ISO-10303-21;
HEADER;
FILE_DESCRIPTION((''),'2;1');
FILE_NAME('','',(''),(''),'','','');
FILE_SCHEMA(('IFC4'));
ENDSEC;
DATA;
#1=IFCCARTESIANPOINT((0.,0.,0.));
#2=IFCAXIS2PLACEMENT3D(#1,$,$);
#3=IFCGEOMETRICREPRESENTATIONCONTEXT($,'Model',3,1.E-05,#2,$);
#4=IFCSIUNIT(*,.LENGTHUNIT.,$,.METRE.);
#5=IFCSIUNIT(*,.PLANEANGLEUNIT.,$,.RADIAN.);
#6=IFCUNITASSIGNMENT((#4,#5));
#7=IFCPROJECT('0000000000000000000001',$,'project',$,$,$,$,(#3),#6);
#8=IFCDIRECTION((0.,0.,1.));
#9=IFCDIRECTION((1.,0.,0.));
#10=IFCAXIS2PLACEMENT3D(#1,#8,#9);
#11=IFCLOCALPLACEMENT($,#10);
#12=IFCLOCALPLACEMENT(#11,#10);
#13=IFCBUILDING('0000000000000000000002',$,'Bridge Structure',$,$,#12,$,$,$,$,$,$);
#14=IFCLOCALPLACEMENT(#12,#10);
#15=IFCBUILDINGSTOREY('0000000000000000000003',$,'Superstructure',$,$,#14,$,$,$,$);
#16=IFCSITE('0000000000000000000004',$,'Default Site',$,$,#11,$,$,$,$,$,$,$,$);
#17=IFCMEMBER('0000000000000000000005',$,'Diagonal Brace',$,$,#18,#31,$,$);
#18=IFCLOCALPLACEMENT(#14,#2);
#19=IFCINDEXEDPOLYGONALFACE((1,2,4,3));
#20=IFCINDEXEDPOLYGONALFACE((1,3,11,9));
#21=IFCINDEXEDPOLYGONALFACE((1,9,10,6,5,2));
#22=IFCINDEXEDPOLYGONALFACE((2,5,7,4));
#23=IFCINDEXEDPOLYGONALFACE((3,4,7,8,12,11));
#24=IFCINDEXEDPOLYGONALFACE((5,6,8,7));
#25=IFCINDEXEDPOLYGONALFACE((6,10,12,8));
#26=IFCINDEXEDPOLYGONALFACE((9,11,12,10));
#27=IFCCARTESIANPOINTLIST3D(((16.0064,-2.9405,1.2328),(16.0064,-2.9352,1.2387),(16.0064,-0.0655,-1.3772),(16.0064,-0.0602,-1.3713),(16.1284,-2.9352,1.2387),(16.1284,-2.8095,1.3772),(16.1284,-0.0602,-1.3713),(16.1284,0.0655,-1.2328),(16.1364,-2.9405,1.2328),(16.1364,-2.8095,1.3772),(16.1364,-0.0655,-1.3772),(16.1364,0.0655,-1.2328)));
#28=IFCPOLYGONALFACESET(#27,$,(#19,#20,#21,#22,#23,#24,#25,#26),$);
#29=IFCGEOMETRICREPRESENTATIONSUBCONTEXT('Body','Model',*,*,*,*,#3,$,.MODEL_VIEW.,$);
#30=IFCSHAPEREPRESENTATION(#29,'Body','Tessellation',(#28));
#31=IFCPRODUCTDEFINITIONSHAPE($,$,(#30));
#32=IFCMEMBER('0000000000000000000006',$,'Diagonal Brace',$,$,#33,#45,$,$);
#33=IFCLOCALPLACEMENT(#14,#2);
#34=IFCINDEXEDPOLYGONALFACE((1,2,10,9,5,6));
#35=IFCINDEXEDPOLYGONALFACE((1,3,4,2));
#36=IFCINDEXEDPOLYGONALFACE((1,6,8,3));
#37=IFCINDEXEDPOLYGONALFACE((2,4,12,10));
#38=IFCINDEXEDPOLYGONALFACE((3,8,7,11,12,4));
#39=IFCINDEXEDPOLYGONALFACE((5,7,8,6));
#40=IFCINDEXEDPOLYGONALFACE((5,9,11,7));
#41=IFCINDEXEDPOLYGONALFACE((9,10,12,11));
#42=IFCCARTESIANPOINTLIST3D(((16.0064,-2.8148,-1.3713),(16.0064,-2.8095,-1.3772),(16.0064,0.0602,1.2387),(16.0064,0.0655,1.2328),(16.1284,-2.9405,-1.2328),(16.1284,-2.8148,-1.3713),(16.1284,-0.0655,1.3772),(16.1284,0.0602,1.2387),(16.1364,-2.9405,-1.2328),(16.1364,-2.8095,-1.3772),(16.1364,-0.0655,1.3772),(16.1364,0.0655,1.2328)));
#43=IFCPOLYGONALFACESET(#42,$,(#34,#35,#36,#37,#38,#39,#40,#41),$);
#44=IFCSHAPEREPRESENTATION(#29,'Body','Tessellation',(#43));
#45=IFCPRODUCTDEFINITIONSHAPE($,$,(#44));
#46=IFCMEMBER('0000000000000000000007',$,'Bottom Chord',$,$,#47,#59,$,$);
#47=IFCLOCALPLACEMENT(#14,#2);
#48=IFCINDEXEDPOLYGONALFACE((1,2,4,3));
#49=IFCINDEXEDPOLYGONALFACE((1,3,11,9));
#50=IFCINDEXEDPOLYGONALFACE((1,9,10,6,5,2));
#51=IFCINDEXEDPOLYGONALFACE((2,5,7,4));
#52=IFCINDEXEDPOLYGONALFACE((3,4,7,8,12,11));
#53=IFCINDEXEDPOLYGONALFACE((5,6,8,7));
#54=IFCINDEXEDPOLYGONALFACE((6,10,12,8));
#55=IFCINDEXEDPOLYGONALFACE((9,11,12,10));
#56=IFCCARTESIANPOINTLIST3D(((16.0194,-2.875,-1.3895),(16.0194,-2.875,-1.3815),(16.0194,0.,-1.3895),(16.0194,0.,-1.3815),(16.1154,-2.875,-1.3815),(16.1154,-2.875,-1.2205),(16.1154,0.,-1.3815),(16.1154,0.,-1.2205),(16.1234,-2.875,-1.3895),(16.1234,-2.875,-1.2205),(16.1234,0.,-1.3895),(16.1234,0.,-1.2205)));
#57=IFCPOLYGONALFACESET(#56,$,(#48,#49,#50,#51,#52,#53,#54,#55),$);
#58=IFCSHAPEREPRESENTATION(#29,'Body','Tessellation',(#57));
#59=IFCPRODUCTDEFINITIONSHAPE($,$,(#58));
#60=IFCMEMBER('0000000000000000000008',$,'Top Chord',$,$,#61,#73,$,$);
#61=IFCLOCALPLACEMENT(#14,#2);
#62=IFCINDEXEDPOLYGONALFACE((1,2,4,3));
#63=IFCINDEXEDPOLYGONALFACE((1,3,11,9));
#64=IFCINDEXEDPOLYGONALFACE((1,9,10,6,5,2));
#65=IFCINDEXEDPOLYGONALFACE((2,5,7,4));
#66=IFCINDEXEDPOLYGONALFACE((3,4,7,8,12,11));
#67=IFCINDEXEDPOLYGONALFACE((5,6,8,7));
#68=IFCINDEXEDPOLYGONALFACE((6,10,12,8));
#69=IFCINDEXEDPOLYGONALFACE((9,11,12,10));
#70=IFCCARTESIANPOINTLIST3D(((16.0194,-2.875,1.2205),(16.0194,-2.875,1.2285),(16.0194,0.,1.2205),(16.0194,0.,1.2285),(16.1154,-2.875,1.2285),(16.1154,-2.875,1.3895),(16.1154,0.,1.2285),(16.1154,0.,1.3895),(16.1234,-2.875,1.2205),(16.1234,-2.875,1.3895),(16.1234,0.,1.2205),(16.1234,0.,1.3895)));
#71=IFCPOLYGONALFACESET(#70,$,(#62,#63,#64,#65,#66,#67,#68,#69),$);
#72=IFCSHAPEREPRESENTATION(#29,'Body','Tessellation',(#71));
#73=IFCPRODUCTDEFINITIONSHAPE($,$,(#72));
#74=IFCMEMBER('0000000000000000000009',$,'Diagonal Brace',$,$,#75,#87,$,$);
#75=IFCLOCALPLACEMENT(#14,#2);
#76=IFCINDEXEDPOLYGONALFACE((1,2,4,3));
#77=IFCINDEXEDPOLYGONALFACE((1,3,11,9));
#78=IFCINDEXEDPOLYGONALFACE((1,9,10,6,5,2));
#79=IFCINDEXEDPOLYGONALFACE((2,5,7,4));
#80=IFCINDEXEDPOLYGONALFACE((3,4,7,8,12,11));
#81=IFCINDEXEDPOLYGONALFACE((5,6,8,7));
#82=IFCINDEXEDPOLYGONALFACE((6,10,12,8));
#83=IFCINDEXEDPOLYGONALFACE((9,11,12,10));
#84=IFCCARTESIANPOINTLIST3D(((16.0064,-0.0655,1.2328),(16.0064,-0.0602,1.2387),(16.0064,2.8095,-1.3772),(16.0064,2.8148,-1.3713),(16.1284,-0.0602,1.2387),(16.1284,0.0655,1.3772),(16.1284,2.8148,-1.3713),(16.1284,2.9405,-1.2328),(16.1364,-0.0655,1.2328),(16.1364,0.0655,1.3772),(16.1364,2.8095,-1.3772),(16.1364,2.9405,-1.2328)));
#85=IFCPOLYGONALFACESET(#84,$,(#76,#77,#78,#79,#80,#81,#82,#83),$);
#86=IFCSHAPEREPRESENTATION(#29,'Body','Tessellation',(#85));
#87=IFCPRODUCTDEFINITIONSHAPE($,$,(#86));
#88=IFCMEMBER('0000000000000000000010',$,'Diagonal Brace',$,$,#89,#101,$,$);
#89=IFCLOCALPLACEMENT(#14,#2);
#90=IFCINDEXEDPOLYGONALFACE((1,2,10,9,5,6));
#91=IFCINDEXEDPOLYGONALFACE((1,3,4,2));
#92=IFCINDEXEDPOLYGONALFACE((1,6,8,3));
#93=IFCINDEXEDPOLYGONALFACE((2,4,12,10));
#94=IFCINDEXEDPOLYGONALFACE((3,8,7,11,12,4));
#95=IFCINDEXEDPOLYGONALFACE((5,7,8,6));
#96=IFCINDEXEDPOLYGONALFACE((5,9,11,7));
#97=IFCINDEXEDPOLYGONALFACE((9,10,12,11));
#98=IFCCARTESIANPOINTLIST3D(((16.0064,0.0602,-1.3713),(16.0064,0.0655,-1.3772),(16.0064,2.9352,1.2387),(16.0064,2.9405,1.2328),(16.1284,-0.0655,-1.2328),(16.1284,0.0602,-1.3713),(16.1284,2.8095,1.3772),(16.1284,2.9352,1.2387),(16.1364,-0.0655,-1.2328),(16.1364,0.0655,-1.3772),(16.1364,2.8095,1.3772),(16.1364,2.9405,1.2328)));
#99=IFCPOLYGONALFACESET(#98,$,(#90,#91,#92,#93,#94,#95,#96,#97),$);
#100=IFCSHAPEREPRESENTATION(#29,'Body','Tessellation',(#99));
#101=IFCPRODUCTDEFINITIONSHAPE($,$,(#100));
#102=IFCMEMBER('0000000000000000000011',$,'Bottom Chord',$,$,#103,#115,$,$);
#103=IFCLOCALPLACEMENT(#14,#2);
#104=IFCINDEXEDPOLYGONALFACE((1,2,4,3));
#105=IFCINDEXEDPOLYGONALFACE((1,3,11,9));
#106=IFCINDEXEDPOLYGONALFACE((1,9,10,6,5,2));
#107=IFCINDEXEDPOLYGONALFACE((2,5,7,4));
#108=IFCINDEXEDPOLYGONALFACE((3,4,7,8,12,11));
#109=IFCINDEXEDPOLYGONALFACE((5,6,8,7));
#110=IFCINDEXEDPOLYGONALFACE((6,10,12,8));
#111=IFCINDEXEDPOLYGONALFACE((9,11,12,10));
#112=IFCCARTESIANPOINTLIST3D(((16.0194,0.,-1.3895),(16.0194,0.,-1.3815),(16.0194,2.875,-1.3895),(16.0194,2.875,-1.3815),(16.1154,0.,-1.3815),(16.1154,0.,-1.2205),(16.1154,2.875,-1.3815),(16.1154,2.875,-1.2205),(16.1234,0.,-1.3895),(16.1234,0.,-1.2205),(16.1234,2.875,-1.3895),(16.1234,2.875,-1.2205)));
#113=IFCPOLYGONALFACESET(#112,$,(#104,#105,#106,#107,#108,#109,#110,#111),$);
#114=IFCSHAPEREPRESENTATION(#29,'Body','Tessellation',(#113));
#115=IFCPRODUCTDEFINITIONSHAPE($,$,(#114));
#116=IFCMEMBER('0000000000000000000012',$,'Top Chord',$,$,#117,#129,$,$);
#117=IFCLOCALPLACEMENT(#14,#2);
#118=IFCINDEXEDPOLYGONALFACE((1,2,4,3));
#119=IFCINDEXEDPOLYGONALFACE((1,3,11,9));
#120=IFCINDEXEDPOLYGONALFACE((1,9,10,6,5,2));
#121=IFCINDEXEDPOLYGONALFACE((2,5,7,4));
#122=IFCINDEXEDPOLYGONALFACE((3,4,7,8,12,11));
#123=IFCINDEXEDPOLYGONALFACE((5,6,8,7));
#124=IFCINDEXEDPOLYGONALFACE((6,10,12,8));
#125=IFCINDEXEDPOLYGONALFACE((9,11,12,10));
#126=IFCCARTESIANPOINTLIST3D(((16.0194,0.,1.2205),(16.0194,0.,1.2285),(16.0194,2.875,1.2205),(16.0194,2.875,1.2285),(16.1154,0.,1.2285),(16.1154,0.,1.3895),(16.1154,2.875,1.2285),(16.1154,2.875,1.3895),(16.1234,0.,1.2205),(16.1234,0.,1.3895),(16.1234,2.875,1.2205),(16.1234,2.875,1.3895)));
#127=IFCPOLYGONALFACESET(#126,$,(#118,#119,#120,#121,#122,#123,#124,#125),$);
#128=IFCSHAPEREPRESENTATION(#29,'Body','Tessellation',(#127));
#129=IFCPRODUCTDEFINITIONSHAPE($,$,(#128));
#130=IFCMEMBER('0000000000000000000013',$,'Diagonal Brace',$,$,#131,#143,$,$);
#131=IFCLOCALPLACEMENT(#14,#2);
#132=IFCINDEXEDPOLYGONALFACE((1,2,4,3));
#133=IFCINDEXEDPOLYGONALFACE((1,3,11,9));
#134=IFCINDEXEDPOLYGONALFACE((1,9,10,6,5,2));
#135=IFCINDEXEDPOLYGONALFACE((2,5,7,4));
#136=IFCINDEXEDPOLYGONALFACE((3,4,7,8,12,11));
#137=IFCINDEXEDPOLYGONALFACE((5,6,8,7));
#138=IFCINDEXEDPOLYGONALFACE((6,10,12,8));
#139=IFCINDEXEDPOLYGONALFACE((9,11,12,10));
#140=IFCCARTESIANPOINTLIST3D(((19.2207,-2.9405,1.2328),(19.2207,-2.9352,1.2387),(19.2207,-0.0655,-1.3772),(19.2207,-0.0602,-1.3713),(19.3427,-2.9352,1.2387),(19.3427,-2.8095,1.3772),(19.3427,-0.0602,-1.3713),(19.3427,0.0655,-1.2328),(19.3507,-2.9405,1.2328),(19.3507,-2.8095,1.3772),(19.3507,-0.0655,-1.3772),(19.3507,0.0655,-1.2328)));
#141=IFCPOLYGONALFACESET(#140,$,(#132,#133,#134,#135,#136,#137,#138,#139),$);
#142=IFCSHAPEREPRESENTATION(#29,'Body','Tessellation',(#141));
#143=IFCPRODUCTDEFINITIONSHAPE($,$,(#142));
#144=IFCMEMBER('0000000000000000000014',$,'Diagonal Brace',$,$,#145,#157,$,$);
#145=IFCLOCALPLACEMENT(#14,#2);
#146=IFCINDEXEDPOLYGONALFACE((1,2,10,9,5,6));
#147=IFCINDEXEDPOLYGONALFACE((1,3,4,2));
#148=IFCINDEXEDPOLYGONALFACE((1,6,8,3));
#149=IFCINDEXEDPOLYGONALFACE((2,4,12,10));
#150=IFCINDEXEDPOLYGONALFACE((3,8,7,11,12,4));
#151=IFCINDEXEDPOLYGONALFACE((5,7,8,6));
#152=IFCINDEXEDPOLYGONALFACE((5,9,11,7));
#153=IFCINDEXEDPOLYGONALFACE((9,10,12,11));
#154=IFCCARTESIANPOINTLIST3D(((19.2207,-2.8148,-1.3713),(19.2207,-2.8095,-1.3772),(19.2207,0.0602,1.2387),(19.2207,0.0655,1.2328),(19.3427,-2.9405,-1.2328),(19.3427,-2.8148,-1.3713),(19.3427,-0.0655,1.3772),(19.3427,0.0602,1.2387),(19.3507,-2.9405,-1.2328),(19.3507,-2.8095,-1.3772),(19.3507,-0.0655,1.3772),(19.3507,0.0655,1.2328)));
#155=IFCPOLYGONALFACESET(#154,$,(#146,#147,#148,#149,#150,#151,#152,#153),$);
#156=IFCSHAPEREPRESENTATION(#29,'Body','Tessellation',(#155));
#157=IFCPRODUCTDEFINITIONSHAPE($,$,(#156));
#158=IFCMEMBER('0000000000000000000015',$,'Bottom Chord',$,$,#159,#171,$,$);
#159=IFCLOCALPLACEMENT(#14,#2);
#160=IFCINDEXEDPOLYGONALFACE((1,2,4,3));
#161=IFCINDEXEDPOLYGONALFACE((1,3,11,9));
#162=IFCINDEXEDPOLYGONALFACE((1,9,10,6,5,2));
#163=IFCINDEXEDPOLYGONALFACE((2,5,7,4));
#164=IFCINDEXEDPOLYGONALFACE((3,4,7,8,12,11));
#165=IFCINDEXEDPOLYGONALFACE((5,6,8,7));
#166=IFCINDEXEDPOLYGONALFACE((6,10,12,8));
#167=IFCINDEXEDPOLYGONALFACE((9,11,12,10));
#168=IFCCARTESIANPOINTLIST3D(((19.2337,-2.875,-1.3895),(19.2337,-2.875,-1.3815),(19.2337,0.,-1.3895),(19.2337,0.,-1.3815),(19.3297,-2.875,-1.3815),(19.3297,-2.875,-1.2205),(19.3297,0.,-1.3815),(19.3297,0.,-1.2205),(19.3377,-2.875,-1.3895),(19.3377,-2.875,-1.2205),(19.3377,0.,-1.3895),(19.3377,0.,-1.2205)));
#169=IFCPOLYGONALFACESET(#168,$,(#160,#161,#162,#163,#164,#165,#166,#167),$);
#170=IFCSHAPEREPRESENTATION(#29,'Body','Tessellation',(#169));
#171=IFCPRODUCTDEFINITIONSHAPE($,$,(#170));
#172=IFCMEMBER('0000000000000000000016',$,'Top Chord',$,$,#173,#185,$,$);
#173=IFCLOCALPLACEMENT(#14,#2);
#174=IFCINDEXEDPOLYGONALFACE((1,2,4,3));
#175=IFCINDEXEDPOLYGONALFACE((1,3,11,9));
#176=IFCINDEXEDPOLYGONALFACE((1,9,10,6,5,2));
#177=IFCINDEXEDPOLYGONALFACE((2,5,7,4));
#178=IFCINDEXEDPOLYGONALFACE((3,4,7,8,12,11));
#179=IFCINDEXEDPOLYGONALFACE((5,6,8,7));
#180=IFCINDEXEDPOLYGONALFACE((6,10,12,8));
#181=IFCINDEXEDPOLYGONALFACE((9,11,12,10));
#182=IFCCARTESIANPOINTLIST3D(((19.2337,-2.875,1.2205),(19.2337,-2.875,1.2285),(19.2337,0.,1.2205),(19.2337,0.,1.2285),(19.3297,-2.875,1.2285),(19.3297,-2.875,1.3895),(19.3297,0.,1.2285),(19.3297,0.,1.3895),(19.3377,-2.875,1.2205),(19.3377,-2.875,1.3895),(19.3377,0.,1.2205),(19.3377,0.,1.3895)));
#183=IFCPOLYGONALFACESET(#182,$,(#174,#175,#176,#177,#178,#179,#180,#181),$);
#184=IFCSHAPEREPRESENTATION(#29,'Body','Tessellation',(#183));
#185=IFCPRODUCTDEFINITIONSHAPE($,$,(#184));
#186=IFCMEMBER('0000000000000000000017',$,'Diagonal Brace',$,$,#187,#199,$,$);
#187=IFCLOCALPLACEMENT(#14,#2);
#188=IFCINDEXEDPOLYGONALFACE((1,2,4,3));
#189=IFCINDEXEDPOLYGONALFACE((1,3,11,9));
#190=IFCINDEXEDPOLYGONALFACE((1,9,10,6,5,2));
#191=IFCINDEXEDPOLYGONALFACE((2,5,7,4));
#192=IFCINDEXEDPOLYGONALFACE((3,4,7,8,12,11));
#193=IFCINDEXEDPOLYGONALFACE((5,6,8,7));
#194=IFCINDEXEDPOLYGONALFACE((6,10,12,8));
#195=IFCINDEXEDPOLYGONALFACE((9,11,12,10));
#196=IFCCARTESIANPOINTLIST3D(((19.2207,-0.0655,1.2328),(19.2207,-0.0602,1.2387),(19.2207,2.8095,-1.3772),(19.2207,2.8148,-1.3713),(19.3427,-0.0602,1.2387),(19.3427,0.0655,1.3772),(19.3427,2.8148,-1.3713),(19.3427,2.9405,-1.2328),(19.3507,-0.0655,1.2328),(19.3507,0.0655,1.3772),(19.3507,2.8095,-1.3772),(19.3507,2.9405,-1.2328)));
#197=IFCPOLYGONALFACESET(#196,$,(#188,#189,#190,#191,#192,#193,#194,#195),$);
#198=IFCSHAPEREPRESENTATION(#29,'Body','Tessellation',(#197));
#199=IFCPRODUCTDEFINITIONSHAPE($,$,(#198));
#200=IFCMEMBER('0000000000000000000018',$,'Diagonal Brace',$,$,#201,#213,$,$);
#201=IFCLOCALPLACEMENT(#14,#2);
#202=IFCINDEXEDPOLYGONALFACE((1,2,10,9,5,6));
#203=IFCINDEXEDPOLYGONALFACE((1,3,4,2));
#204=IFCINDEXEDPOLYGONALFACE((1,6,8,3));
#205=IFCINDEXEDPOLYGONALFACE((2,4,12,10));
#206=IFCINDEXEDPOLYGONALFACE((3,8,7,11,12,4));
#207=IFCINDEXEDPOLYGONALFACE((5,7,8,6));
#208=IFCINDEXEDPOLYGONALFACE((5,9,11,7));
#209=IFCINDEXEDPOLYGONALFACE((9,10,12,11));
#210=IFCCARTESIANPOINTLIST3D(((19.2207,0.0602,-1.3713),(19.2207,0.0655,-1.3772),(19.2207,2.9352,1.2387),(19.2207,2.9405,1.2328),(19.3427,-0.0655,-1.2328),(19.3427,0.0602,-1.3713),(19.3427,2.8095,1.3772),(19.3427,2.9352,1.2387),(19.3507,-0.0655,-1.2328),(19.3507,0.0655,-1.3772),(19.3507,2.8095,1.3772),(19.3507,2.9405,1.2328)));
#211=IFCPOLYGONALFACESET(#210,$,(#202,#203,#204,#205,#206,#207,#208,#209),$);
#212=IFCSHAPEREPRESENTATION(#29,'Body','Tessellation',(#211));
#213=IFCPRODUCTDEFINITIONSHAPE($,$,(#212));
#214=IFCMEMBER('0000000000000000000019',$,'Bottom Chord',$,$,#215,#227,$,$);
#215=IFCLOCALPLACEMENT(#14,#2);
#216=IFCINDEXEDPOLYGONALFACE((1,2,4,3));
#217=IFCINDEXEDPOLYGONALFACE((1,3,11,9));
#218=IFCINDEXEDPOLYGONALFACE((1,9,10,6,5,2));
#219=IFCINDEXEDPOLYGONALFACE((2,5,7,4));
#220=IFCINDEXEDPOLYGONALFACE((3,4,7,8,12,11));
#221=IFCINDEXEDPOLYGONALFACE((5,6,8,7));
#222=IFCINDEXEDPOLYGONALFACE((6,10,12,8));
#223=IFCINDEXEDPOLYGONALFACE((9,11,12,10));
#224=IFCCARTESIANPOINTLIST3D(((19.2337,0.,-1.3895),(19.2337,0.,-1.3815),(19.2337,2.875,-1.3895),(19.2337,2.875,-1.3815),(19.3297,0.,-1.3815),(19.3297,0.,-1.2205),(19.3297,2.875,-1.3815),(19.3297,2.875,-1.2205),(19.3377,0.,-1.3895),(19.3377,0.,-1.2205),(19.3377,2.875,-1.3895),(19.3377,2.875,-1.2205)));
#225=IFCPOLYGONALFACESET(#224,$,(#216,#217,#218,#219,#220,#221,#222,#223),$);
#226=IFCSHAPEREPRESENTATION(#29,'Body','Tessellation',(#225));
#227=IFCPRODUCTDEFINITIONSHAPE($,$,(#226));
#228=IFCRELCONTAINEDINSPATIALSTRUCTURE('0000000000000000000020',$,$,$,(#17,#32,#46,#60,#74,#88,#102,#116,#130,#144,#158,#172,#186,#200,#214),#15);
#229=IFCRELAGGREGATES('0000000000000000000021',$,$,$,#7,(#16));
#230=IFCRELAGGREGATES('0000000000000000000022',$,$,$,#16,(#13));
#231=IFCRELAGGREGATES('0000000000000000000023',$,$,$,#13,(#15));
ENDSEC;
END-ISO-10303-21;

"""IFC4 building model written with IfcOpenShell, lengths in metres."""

from ifc_helpers import new_model, si_unit, frame, origin, origin_with_axes, origin_2d_with_axis, place, context, subcontext, project, spatial, l_section, extrude, element, save


model = new_model("IFC4")

# Units and contexts
model_context = context("Model", 3, precision=1e-05, world=origin())
body_context = subcontext(model_context, "Body", "Model", "MODEL_VIEW")
ifc_project = project(units=[si_unit("LENGTHUNIT", "METRE"), si_unit("PLANEANGLEUNIT", "RADIAN")], contexts=[model_context])

# Site, building, storey
site_placement = place(None, origin_with_axes())
site = spatial("IfcSite", under=ifc_project, at=site_placement, Name="Default Site")
building_placement = place(site_placement, origin_with_axes())
building = spatial("IfcBuilding", under=site, at=building_placement, Name="Bridge Structure")
storey_placement = place(building_placement, origin_with_axes())
storey = spatial("IfcBuildingStorey", under=building, at=storey_placement, Name="Superstructure")

# Members
for number, where, z_axis, x_axis, name in (
    (1, (16.0714, -2.875, 1.305), (0.0, 0.740406, -0.67216), (-1.0, 0.0, 0.0), "Diagonal Brace"),
    (2, (16.0714, -2.875, -1.305), (0.0, 0.740406, 0.67216), (-1.0, 0.0, 0.0), "Diagonal Brace"),
):
    element("IfcMember", number, at=place(storey_placement, frame(where, z_axis=z_axis, x_axis=x_axis)), inside=storey, Name=name, context=body_context, shape_type="SweptSolid", body=[
        extrude(l_section(Depth=0.195, Width=0.13, Thickness=0.008, at=origin_2d_with_axis()), origin_with_axes(), (0.0, 0.0, 1.0), 3.883),
    ])
for number, where, z_axis, x_axis, name in (
    (3, (16.0714, -2.875, -1.305), (0.0, 1.0, 0.0), (-1.0, 0.0, 0.0), "Bottom Chord"),
    (4, (16.0714, -2.875, 1.305), (0.0, 1.0, 0.0), (-1.0, 0.0, 0.0), "Top Chord"),
):
    element("IfcMember", number, at=place(storey_placement, frame(where, z_axis=z_axis, x_axis=x_axis)), inside=storey, Name=name, context=body_context, shape_type="SweptSolid", body=[
        extrude(l_section(Depth=0.169, Width=0.104, Thickness=0.008, at=origin_2d_with_axis()), origin_with_axes(), (0.0, 0.0, 1.0), 2.875),
    ])
for number, where, z_axis, x_axis, name in (
    (5, (16.0714, 0.0, 1.305), (0.0, 0.740406, -0.67216), (-1.0, 0.0, 0.0), "Diagonal Brace"),
    (6, (16.0714, 0.0, -1.305), (0.0, 0.740406, 0.67216), (-1.0, 0.0, 0.0), "Diagonal Brace"),
):
    element("IfcMember", number, at=place(storey_placement, frame(where, z_axis=z_axis, x_axis=x_axis)), inside=storey, Name=name, context=body_context, shape_type="SweptSolid", body=[
        extrude(l_section(Depth=0.195, Width=0.13, Thickness=0.008, at=origin_2d_with_axis()), origin_with_axes(), (0.0, 0.0, 1.0), 3.883),
    ])
for number, where, z_axis, x_axis, name in (
    (7, (16.0714, 0.0, -1.305), (0.0, 1.0, 0.0), (-1.0, 0.0, 0.0), "Bottom Chord"),
    (8, (16.0714, 0.0, 1.305), (0.0, 1.0, 0.0), (-1.0, 0.0, 0.0), "Top Chord"),
):
    element("IfcMember", number, at=place(storey_placement, frame(where, z_axis=z_axis, x_axis=x_axis)), inside=storey, Name=name, context=body_context, shape_type="SweptSolid", body=[
        extrude(l_section(Depth=0.169, Width=0.104, Thickness=0.008, at=origin_2d_with_axis()), origin_with_axes(), (0.0, 0.0, 1.0), 2.875),
    ])
for number, where, z_axis, x_axis, name in (
    (9, (19.2857, -2.875, 1.305), (0.0, 0.740406, -0.67216), (-1.0, 0.0, 0.0), "Diagonal Brace"),
    (10, (19.2857, -2.875, -1.305), (0.0, 0.740406, 0.67216), (-1.0, 0.0, 0.0), "Diagonal Brace"),
):
    element("IfcMember", number, at=place(storey_placement, frame(where, z_axis=z_axis, x_axis=x_axis)), inside=storey, Name=name, context=body_context, shape_type="SweptSolid", body=[
        extrude(l_section(Depth=0.195, Width=0.13, Thickness=0.008, at=origin_2d_with_axis()), origin_with_axes(), (0.0, 0.0, 1.0), 3.883),
    ])
for number, where, z_axis, x_axis, name in (
    (11, (19.2857, -2.875, -1.305), (0.0, 1.0, 0.0), (-1.0, 0.0, 0.0), "Bottom Chord"),
    (12, (19.2857, -2.875, 1.305), (0.0, 1.0, 0.0), (-1.0, 0.0, 0.0), "Top Chord"),
):
    element("IfcMember", number, at=place(storey_placement, frame(where, z_axis=z_axis, x_axis=x_axis)), inside=storey, Name=name, context=body_context, shape_type="SweptSolid", body=[
        extrude(l_section(Depth=0.169, Width=0.104, Thickness=0.008, at=origin_2d_with_axis()), origin_with_axes(), (0.0, 0.0, 1.0), 2.875),
    ])
for number, where, z_axis, x_axis, name in (
    (13, (19.2857, 0.0, 1.305), (0.0, 0.740406, -0.67216), (-1.0, 0.0, 0.0), "Diagonal Brace"),
    (14, (19.2857, 0.0, -1.305), (0.0, 0.740406, 0.67216), (-1.0, 0.0, 0.0), "Diagonal Brace"),
):
    element("IfcMember", number, at=place(storey_placement, frame(where, z_axis=z_axis, x_axis=x_axis)), inside=storey, Name=name, context=body_context, shape_type="SweptSolid", body=[
        extrude(l_section(Depth=0.195, Width=0.13, Thickness=0.008, at=origin_2d_with_axis()), origin_with_axes(), (0.0, 0.0, 1.0), 3.883),
    ])
for number, where, z_axis, x_axis, name in (
    (15, (19.2857, 0.0, -1.305), (0.0, 1.0, 0.0), (-1.0, 0.0, 0.0), "Bottom Chord"),
):
    element("IfcMember", number, at=place(storey_placement, frame(where, z_axis=z_axis, x_axis=x_axis)), inside=storey, Name=name, context=body_context, shape_type="SweptSolid", body=[
        extrude(l_section(Depth=0.169, Width=0.104, Thickness=0.008, at=origin_2d_with_axis()), origin_with_axes(), (0.0, 0.0, 1.0), 2.875),
    ])

save(model, "model.ifc")
